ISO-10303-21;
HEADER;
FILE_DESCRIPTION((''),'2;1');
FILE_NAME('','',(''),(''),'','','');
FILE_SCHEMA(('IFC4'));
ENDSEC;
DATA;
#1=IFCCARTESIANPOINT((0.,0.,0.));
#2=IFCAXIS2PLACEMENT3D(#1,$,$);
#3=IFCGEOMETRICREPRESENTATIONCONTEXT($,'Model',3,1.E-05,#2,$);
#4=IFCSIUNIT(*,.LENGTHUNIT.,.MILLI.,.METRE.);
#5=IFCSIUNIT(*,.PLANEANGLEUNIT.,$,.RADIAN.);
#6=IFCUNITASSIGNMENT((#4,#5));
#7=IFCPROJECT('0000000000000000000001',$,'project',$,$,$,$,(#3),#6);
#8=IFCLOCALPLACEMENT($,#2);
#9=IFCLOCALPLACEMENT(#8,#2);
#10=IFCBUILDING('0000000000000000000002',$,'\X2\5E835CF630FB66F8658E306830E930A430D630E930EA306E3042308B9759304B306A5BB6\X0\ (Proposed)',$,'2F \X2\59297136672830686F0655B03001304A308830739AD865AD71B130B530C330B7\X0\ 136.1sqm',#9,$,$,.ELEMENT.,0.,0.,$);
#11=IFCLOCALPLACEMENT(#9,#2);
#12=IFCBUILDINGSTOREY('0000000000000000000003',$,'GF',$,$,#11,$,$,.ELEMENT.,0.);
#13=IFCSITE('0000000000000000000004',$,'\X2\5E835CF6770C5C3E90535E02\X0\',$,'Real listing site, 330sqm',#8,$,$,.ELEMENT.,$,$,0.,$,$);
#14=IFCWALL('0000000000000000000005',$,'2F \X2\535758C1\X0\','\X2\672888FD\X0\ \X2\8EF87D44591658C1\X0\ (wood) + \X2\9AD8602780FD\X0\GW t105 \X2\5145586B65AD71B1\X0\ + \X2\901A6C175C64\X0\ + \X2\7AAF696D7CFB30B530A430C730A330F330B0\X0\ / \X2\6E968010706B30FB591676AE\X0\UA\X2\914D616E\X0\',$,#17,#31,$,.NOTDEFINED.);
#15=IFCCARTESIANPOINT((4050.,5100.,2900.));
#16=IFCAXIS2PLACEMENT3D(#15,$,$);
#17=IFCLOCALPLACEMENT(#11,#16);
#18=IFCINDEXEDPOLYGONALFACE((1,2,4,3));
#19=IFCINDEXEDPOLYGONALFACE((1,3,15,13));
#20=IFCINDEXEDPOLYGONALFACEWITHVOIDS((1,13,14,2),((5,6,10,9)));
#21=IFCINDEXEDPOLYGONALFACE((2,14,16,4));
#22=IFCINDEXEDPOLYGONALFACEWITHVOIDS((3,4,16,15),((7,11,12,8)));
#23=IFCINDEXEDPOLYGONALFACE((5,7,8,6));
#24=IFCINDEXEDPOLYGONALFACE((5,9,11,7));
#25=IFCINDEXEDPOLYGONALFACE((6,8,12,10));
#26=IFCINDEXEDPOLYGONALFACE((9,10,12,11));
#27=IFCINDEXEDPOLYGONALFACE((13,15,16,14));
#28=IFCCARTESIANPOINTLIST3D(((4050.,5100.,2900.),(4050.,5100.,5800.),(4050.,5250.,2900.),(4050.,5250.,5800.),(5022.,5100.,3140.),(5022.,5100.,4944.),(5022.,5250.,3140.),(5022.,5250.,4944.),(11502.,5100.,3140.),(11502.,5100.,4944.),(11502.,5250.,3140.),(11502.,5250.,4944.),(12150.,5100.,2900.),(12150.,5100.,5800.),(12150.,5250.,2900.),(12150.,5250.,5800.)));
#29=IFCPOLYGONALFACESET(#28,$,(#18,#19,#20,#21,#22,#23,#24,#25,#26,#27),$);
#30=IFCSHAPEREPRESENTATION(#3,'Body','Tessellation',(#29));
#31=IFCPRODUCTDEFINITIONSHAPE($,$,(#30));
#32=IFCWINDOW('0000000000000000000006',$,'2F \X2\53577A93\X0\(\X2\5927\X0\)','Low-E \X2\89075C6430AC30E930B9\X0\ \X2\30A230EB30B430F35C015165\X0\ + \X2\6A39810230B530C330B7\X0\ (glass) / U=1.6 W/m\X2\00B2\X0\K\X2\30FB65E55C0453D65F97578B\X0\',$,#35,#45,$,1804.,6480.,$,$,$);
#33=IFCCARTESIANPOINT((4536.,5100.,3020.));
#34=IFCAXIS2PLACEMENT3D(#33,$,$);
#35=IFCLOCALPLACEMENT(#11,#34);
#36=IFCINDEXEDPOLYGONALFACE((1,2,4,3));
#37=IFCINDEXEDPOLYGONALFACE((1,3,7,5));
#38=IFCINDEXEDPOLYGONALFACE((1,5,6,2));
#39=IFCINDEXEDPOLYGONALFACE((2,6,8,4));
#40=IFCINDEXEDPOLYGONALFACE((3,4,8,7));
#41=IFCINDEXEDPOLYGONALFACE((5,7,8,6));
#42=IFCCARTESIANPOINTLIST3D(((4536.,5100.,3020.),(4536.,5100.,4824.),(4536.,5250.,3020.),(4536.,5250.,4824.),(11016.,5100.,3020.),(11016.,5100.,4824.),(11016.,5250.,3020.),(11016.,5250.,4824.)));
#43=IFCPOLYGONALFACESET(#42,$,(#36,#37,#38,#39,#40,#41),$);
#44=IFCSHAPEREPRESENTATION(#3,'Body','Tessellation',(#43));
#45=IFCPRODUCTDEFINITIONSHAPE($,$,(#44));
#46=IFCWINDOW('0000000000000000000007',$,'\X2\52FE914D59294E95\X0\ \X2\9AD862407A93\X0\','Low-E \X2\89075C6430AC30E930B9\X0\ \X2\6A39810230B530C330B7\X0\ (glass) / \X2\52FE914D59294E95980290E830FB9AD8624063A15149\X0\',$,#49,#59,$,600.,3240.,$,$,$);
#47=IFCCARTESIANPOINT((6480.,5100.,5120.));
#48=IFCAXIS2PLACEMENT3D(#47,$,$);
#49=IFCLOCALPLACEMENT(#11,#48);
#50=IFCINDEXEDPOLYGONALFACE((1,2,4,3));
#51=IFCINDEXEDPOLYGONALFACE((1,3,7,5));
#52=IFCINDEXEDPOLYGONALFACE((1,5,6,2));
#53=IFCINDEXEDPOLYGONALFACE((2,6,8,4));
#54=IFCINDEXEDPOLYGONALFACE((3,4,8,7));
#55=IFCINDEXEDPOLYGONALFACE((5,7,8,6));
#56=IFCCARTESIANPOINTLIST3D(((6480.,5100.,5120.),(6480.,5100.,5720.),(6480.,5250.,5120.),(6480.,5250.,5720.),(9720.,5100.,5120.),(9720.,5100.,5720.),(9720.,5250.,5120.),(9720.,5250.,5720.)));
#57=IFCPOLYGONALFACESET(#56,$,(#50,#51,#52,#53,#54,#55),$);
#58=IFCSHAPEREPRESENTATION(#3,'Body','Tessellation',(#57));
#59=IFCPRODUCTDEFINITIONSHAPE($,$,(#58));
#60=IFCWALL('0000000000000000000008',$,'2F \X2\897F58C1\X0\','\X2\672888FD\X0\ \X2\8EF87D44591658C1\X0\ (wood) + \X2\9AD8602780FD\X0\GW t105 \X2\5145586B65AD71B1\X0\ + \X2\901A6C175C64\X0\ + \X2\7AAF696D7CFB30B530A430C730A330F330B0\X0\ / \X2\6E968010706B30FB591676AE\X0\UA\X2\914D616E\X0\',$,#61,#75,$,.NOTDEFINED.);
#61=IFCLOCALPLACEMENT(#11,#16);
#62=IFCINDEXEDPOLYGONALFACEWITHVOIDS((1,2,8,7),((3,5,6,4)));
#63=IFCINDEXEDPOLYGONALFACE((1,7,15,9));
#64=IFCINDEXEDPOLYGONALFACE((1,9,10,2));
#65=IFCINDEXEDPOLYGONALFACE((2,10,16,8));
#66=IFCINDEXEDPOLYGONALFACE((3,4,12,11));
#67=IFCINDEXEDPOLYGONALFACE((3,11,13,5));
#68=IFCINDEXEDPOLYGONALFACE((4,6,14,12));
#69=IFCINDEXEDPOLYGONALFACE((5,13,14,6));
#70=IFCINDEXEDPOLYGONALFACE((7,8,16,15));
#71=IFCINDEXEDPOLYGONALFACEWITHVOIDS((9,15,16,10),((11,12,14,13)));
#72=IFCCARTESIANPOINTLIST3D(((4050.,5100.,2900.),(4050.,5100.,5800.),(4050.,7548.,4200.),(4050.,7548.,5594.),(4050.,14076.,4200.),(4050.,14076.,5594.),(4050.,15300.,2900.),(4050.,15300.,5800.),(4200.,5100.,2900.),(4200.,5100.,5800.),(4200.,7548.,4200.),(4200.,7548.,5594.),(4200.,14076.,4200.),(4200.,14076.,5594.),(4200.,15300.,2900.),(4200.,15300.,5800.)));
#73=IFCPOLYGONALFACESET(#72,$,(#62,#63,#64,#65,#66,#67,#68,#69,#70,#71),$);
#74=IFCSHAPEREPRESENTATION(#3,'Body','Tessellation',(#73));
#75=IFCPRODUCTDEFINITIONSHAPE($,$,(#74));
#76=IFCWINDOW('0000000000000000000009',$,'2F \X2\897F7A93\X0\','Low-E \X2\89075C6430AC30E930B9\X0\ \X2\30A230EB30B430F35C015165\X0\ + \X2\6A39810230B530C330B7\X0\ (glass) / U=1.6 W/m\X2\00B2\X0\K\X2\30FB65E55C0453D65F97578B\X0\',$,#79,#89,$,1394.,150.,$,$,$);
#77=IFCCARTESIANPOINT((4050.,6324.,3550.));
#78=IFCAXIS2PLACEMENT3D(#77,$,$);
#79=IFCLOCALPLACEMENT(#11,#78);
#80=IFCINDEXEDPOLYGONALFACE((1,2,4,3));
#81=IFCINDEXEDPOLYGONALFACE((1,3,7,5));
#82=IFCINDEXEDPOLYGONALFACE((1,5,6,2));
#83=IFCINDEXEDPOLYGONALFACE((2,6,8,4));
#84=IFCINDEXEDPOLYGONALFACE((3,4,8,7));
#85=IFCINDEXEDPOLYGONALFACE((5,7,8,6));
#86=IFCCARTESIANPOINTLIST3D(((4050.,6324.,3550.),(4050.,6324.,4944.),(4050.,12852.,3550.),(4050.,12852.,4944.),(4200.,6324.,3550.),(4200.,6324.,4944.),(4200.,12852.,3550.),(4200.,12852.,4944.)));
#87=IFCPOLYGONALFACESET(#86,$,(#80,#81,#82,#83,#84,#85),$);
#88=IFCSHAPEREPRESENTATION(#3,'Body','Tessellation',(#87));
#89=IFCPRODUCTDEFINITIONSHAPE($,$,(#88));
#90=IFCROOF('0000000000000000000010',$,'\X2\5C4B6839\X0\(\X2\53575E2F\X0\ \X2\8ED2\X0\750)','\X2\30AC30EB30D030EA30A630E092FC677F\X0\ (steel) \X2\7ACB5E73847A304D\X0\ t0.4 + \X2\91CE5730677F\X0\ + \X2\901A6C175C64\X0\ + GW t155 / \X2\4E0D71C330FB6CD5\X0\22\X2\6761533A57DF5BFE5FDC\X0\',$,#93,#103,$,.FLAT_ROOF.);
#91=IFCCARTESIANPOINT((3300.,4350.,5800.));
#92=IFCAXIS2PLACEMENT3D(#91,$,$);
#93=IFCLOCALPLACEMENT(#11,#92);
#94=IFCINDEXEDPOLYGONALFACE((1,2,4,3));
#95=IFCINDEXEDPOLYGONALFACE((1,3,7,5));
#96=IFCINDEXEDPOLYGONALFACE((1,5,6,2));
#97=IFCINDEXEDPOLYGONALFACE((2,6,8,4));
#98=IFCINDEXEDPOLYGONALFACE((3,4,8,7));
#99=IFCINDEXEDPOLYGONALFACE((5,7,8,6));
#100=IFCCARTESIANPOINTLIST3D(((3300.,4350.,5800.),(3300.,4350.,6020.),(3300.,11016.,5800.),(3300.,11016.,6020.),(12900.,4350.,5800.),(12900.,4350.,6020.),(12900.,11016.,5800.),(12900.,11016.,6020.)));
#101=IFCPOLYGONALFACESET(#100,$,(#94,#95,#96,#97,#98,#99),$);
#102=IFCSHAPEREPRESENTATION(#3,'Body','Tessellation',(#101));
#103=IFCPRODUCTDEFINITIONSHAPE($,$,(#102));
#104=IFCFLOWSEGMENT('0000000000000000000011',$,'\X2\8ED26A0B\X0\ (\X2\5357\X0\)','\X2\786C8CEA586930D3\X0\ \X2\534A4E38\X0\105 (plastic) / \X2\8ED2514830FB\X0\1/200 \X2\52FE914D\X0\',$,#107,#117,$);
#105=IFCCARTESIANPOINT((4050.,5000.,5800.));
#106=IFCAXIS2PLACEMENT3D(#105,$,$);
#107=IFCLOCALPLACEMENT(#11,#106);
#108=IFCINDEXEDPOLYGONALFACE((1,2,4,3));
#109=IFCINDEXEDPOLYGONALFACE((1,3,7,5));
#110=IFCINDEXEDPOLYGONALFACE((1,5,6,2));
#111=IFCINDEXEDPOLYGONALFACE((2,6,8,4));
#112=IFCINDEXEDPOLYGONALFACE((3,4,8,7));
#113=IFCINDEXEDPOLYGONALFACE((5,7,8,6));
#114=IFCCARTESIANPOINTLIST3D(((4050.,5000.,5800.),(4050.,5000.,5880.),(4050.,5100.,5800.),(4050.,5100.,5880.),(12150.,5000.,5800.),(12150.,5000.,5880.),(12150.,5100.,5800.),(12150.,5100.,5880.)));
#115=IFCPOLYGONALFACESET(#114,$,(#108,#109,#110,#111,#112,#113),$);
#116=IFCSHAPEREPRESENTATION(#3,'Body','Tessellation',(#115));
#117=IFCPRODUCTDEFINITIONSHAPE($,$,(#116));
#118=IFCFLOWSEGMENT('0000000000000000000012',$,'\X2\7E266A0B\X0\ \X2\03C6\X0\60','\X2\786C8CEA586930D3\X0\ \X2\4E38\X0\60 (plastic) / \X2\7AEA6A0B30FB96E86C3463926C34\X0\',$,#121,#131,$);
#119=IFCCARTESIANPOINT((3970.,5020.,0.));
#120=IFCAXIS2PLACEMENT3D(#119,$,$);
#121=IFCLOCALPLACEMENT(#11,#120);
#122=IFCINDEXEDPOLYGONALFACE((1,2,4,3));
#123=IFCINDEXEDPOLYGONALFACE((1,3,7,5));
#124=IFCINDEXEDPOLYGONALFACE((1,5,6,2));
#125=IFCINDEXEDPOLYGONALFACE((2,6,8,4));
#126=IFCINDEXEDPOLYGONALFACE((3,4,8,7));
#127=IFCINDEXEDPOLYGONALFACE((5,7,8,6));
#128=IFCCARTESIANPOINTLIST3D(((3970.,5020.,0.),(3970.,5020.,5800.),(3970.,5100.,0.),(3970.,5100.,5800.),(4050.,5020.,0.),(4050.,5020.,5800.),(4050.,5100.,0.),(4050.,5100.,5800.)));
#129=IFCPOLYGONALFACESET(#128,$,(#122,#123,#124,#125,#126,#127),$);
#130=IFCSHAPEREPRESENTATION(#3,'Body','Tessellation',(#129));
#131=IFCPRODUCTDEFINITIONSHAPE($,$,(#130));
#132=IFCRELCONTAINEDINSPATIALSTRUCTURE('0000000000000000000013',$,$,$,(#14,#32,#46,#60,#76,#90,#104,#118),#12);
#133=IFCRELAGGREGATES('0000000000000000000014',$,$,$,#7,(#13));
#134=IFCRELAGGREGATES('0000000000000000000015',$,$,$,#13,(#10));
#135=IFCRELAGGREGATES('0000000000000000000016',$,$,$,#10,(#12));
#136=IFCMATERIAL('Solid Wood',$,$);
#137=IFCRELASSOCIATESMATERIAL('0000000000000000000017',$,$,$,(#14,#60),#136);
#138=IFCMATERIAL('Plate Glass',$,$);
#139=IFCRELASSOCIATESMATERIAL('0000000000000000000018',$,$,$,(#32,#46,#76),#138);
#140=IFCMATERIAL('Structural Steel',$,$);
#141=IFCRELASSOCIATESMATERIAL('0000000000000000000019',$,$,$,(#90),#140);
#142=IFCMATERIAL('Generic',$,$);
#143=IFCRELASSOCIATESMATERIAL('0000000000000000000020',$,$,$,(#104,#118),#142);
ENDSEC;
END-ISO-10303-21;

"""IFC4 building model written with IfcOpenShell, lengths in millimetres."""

from ifc_helpers import new_model, si_unit, frame, frame_2d, origin, place, context, project, spatial, rectangle, extrude, material, element, fill, save


model = new_model("IFC4")

# Units and contexts
model_context = context("Model", 3, precision=1e-05, world=origin())
ifc_project = project(units=[si_unit("LENGTHUNIT", "METRE", prefix="MILLI"), si_unit("PLANEANGLEUNIT", "RADIAN")], contexts=[model_context])

# Site, building, storey
site_placement = place(None, origin())
site = spatial("IfcSite", under=ifc_project, at=site_placement, Name="広島県尾道市", ObjectType="Real listing site, 330sqm", CompositionType="ELEMENT", RefElevation=0.0)
building_placement = place(site_placement, origin())
building = spatial("IfcBuilding", under=site, at=building_placement, Name="広島・書斎とライブラリのある静かな家 (Proposed)", ObjectType="2F 天然木と漆喰、および高断熱サッシ 136.1sqm", CompositionType="ELEMENT", ElevationOfRefHeight=0.0, ElevationOfTerrain=0.0)
storey_placement = place(building_placement, origin())
storey = spatial("IfcBuildingStorey", under=building, at=storey_placement, Name="GF", CompositionType="ELEMENT", Elevation=0.0)

# Shared definitions
ifc_material_1 = material(Name="Solid Wood")

# Shared definitions
ifc_material_2 = material(Name="Plate Glass")

# Wall, openings, windows
wall_1_placement = place(storey_placement, frame((4050.0, 5100.0, 2900.0)))
wall_1 = element("IfcWall", 1, at=wall_1_placement, inside=storey, material=ifc_material_1, Name="2F 南壁", Description="木製 軸組外壁 (wood) + 高性能GW t105 充填断熱 + 通気層 + 窯業系サイディング / 準耐火・外皮UA配慮", PredefinedType="NOTDEFINED", context=model_context, shape_type="SweptSolid", body=[
    extrude(rectangle(XDim=8100.0, YDim=150.0, at=frame_2d((4050.0, 75.0))), frame((4050.0, 5100.0, 2900.0)), (0.0, 0.0, 1.0), 2900.0),
])
opening_1_placement = place(storey_placement, frame((4536.0, 5100.0, 3020.0)))
opening_1 = element("IfcOpeningElement", 2, at=opening_1_placement, cuts=wall_1, PredefinedType="NOTDEFINED", context=model_context, shape_type="SweptSolid", body=[
    extrude(rectangle(XDim=6480.0, YDim=150.0, at=frame_2d((3240.0, 75.0))), frame((4536.0, 5100.0, 3020.0)), (0.0, 0.0, 1.0), 1804.0),
])
opening_2_placement = place(storey_placement, frame((6480.0, 5100.0, 5120.0)))
opening_2 = element("IfcOpeningElement", 3, at=opening_2_placement, cuts=wall_1, PredefinedType="NOTDEFINED", context=model_context, shape_type="SweptSolid", body=[
    extrude(rectangle(XDim=3240.0, YDim=150.0, at=frame_2d((1620.0, 75.0))), frame((6480.0, 5100.0, 5120.0)), (0.0, 0.0, 1.0), 600.0),
])
window_1_placement = place(storey_placement, frame((4536.0, 5100.0, 3020.0)))
window_1 = element("IfcWindow", 4, at=window_1_placement, inside=storey, material=ifc_material_2, Name="2F 南窓(大)", Description="Low-E 複層ガラス アルゴン封入 + 樹脂サッシ (glass) / U=1.6 W/m²K・日射取得型", OverallHeight=1804.0, OverallWidth=6480.0, context=model_context, shape_type="SweptSolid", body=[
    extrude(rectangle(XDim=6480.0, YDim=150.0, at=frame_2d((3240.0, 75.0))), frame((4536.0, 5100.0, 3020.0)), (0.0, 0.0, 1.0), 1804.0),
])
fill(opening_1, window_1)
window_2_placement = place(storey_placement, frame((6480.0, 5100.0, 5120.0)))
window_2 = element("IfcWindow", 5, at=window_2_placement, inside=storey, material=ifc_material_2, Name="勾配天井 高所窓", Description="Low-E 複層ガラス 樹脂サッシ (glass) / 勾配天井頂部・高所採光", OverallHeight=600.0, OverallWidth=3240.0, context=model_context, shape_type="SweptSolid", body=[
    extrude(rectangle(XDim=3240.0, YDim=150.0, at=frame_2d((1620.0, 75.0))), frame((6480.0, 5100.0, 5120.0)), (0.0, 0.0, 1.0), 600.0),
])
fill(opening_2, window_2)

# Wall, opening, window
wall_2_placement = place(storey_placement, frame((4050.0, 5100.0, 2900.0)))
wall_2 = element("IfcWall", 6, at=wall_2_placement, inside=storey, material=ifc_material_1, Name="2F 西壁", Description="木製 軸組外壁 (wood) + 高性能GW t105 充填断熱 + 通気層 + 窯業系サイディング / 準耐火・外皮UA配慮", PredefinedType="NOTDEFINED", context=model_context, shape_type="SweptSolid", body=[
    extrude(rectangle(XDim=150.0, YDim=10200.0, at=frame_2d((75.0, 5100.0))), frame((4050.0, 5100.0, 2900.0)), (0.0, 0.0, 1.0), 2900.0),
])
opening_3_placement = place(storey_placement, frame((4050.0, 6324.0, 3550.0)))
opening_3 = element("IfcOpeningElement", 7, at=opening_3_placement, cuts=wall_2, PredefinedType="NOTDEFINED", context=model_context, shape_type="SweptSolid", body=[
    extrude(rectangle(XDim=150.0, YDim=6528.0, at=frame_2d((75.0, 3264.0))), frame((4050.0, 6324.0, 3550.0)), (0.0, 0.0, 1.0), 1394.0),
])
window_3_placement = place(storey_placement, frame((4050.0, 6324.0, 3550.0)))
window_3 = element("IfcWindow", 8, at=window_3_placement, inside=storey, material=ifc_material_2, Name="2F 西窓", Description="Low-E 複層ガラス アルゴン封入 + 樹脂サッシ (glass) / U=1.6 W/m²K・日射取得型", OverallHeight=1394.0, OverallWidth=150.0, context=model_context, shape_type="SweptSolid", body=[
    extrude(rectangle(XDim=150.0, YDim=6528.0, at=frame_2d((75.0, 3264.0))), frame((4050.0, 6324.0, 3550.0)), (0.0, 0.0, 1.0), 1394.0),
])
fill(opening_3, window_3)

# Roof
ifc_material_3 = material(Name="Structural Steel")
for number, where, name in (
    (9, (3300.0, 4350.0, 5800.0), "屋根(南帯 軒750)"),
):
    element("IfcRoof", number, at=place(storey_placement, frame(where)), inside=storey, material=ifc_material_3, Name=name, Description="ガルバリウム鋼板 (steel) 立平葺き t0.4 + 野地板 + 通気層 + GW t155 / 不燃・法22条区域対応", PredefinedType="FLAT_ROOF", context=model_context, shape_type="SweptSolid", body=[
        extrude(rectangle(XDim=9600.0, YDim=6666.0, at=frame_2d((4800.0, 3333.0))), frame((3300.0, 4350.0, 5800.0)), (0.0, 0.0, 1.0), 220.0),
    ])

# Flow segments
ifc_material_4 = material(Name="Generic")
flow_segment_1_placement = place(storey_placement, frame((4050.0, 5000.0, 5800.0)))
element("IfcFlowSegment", 10, at=flow_segment_1_placement, inside=storey, material=ifc_material_4, Name="軒樋 (南)", Description="硬質塩ビ 半丸105 (plastic) / 軒先・1/200 勾配", context=model_context, shape_type="SweptSolid", body=[
    extrude(rectangle(XDim=8100.0, YDim=100.0, at=frame_2d((4050.0, 50.0))), frame((4050.0, 5000.0, 5800.0)), (0.0, 0.0, 1.0), 80.0),
])
flow_segment_2_placement = place(storey_placement, frame((3970.0, 5020.0, 0.0)))
element("IfcFlowSegment", 11, at=flow_segment_2_placement, inside=storey, material=ifc_material_4, Name="縦樋 φ60", Description="硬質塩ビ 丸60 (plastic) / 竪樋・雨水排水", context=model_context, shape_type="SweptSolid", body=[
    extrude(rectangle(XDim=80.0, YDim=80.0, at=frame_2d((40.0, 40.0))), frame((3970.0, 5020.0, 0.0)), (0.0, 0.0, 1.0), 5800.0),
])

save(model, "model.ifc")
